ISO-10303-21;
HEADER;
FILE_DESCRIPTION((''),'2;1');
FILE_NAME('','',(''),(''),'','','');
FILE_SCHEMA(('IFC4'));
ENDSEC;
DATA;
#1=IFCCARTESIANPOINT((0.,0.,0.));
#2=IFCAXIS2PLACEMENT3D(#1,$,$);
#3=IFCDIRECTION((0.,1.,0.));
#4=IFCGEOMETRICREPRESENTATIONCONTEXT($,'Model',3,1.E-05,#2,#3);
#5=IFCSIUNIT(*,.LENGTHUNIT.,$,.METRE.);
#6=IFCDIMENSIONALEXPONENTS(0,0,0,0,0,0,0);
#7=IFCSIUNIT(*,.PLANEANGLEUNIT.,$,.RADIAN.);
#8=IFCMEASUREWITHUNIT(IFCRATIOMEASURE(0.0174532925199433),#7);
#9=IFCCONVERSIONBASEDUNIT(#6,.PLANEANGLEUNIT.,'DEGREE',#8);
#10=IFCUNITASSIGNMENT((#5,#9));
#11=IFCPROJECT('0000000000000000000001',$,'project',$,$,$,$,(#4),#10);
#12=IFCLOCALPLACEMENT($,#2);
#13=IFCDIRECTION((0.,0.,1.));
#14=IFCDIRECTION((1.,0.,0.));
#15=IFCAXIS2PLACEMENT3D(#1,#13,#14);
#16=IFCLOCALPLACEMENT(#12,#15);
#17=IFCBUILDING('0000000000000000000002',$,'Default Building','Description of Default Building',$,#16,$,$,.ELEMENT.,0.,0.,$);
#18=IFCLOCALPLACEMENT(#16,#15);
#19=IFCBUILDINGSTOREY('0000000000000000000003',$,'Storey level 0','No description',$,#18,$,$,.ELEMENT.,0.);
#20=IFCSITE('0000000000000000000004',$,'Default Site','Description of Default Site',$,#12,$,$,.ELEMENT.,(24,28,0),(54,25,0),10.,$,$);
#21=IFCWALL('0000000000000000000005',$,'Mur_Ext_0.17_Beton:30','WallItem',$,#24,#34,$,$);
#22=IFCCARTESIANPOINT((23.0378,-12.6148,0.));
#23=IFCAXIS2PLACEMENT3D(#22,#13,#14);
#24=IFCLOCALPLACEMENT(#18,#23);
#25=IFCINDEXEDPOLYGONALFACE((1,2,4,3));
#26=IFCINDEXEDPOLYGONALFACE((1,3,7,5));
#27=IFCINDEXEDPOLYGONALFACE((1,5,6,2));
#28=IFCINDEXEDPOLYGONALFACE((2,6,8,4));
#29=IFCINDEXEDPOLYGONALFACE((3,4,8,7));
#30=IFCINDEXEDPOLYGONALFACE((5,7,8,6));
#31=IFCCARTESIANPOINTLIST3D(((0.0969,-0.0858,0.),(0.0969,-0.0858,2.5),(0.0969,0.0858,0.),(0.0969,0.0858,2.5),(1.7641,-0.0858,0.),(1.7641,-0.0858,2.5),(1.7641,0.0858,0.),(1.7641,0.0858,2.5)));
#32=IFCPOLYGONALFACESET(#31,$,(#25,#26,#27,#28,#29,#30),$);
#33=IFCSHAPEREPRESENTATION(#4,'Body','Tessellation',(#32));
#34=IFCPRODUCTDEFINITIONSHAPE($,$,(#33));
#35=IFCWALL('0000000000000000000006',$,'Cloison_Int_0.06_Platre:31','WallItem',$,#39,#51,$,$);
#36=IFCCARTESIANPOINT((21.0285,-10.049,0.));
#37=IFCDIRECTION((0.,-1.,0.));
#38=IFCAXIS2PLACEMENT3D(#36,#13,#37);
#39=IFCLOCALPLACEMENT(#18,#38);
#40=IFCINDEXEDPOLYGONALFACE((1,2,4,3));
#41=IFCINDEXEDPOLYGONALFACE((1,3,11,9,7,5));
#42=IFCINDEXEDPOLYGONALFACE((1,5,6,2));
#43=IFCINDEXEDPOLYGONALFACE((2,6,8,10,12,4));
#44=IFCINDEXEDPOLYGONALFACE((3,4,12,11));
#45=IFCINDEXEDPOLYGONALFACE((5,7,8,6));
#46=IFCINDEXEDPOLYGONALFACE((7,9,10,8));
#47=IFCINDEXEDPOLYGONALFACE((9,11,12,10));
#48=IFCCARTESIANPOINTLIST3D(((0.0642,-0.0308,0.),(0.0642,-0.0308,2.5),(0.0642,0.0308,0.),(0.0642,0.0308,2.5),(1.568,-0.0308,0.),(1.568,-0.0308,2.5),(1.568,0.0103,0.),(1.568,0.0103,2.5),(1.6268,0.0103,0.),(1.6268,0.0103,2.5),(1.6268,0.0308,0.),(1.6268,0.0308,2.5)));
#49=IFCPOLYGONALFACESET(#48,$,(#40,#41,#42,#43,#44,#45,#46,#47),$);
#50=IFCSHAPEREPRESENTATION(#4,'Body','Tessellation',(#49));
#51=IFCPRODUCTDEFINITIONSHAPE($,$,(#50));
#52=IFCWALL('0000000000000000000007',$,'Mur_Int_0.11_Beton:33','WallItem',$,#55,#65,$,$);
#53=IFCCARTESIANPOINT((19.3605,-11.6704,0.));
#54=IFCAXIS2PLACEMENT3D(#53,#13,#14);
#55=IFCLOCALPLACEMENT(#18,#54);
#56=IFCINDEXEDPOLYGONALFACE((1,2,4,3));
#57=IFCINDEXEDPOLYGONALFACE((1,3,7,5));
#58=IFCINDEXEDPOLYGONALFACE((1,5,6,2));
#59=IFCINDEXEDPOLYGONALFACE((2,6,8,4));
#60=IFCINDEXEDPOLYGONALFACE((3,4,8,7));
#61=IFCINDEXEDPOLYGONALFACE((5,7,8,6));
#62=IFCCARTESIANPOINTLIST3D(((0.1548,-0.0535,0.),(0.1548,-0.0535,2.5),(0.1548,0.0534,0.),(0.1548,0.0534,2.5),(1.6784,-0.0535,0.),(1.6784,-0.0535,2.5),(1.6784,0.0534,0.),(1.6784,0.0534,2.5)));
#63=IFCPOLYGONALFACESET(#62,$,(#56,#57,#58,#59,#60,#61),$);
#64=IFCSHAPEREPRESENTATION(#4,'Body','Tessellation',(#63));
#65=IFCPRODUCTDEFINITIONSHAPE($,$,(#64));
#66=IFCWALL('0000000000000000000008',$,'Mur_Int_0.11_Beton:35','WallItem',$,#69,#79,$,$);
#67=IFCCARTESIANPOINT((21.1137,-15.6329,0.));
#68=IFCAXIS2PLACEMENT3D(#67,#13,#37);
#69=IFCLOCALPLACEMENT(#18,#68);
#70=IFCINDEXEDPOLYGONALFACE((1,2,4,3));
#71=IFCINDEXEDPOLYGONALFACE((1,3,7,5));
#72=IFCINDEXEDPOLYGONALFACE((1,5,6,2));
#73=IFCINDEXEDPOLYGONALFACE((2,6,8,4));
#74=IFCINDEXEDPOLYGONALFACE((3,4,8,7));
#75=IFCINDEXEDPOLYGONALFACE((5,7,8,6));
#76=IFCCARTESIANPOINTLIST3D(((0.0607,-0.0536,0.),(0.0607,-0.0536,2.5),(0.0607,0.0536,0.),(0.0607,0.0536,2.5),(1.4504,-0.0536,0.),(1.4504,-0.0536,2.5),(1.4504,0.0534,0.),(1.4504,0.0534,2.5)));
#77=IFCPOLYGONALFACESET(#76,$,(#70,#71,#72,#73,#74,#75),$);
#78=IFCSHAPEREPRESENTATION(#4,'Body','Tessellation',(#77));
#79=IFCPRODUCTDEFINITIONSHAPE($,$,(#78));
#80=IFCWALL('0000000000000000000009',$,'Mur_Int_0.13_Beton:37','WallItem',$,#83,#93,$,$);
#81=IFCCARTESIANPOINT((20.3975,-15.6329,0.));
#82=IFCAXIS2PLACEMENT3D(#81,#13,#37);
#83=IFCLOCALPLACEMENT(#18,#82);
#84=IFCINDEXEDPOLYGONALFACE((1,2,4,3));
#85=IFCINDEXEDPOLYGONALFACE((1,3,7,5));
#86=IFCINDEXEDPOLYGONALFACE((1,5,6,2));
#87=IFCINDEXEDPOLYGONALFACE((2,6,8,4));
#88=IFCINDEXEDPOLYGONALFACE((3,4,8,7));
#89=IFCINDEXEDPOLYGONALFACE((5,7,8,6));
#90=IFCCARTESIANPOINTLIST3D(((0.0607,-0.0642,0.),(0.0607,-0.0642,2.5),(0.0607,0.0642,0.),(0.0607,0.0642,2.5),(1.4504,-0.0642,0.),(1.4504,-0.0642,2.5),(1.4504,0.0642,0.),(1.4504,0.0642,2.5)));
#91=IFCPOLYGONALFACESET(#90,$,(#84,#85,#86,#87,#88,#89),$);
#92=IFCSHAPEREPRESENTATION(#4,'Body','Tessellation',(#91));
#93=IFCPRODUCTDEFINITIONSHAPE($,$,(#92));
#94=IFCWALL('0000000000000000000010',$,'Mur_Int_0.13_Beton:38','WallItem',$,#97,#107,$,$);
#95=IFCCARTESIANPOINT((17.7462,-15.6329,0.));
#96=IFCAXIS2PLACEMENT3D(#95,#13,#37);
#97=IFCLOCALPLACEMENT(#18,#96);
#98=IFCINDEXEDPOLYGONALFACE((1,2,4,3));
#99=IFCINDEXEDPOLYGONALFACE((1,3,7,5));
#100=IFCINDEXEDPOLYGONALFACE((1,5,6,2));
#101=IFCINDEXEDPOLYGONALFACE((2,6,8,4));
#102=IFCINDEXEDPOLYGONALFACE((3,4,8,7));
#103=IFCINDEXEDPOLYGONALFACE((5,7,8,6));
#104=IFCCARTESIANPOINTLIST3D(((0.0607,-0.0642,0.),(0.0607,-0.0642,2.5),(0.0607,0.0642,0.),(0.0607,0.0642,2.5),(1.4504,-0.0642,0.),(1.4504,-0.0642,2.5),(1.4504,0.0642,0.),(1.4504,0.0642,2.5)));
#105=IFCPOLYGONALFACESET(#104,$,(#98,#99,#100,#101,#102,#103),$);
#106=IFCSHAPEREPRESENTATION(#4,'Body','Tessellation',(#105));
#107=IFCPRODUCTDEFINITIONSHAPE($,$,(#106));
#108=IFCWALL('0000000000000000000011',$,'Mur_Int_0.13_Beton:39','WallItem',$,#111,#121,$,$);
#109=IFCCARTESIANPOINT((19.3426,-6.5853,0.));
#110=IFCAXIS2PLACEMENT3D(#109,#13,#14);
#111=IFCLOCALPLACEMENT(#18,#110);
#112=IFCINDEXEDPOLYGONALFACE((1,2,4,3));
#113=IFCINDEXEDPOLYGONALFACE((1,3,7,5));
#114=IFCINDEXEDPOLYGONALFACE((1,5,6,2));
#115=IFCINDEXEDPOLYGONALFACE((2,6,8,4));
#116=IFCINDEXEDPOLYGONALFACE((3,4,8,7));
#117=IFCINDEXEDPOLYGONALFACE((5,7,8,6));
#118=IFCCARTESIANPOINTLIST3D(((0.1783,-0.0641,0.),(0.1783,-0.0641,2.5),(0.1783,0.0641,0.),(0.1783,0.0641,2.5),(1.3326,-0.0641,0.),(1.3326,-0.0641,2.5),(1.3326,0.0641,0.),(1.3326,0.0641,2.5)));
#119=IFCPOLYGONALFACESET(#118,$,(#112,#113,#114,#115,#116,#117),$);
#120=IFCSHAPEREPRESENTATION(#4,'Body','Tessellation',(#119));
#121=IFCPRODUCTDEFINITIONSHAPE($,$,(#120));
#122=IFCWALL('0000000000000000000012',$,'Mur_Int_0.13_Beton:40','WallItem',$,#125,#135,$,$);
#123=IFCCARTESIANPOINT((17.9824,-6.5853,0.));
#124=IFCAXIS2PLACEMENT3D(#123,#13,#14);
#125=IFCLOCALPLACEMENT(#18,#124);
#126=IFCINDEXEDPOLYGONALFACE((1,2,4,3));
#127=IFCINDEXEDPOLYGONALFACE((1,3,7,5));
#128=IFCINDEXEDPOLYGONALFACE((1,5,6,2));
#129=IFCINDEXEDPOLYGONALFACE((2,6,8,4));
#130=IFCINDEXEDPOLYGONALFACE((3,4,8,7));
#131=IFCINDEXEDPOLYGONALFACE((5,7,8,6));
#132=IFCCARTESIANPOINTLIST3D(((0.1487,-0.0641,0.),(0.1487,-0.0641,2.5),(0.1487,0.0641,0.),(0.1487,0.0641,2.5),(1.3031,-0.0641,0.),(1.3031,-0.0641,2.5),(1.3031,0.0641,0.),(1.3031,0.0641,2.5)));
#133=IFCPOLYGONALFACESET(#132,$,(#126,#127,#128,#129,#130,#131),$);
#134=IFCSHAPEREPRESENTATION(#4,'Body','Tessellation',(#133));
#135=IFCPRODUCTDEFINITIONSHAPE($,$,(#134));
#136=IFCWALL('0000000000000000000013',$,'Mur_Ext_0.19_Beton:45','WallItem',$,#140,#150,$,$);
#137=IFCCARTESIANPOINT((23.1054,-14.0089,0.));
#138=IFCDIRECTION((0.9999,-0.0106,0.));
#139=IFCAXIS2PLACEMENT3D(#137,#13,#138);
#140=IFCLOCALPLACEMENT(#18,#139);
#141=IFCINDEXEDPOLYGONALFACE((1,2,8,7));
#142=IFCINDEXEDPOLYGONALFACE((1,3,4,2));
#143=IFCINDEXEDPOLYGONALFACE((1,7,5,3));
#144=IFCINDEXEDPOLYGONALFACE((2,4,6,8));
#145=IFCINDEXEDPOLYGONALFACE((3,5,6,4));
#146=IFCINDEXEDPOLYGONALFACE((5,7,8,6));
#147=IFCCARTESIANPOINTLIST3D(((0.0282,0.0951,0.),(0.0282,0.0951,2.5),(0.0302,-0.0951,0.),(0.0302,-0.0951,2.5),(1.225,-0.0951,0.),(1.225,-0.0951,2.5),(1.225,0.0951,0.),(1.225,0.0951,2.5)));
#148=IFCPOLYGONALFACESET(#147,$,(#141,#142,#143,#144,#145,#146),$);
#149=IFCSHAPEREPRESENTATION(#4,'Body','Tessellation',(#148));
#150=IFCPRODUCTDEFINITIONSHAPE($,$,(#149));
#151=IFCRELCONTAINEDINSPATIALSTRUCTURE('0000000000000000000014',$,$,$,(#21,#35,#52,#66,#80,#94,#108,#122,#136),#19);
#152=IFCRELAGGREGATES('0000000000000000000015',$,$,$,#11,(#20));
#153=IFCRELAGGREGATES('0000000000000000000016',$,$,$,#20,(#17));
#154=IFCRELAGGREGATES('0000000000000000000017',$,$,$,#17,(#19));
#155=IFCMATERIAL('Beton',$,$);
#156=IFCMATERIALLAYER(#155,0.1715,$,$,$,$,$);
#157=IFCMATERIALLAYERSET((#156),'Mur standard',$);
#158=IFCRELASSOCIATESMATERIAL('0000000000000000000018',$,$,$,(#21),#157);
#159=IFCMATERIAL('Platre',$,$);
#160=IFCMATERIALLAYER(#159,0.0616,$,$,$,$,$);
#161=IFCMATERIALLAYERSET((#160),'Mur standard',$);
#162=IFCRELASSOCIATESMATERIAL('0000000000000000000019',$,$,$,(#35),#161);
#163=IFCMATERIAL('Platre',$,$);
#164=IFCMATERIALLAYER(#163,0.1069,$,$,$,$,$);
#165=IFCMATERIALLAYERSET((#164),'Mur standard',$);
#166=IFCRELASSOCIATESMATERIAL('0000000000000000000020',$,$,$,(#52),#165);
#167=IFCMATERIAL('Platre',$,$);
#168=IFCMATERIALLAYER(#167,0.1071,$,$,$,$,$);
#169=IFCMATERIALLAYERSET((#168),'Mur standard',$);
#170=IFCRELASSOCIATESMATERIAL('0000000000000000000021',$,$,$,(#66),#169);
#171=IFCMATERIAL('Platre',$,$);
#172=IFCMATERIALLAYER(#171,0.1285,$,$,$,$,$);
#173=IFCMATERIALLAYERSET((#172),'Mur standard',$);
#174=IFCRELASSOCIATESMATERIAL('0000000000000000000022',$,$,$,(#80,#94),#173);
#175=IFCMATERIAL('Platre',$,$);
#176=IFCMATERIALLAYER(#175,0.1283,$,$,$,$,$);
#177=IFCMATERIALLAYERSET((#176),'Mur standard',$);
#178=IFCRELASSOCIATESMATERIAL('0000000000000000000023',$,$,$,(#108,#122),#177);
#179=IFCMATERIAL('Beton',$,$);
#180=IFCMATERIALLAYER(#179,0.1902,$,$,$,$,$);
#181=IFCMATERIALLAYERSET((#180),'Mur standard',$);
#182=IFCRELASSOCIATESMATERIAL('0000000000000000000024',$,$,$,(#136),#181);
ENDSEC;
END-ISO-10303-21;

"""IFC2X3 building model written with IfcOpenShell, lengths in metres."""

from ifc_helpers import new_model, entity, si_unit, converted_unit, direction, frame, origin, origin_with_axes, place, context, project, spatial, polyline, outline, extrude, material, layer, layer_set, layer_usage, element, save


model = new_model("IFC2X3")

# Units and contexts
model_context = context("Model", 3, precision=1e-05, world=origin(), true_north=direction((0.0, 1.0, 0.0)))
ifc_project = project(units=[si_unit("LENGTHUNIT", "METRE"), converted_unit("PLANEANGLEUNIT", "DEGREE", entity("IfcRatioMeasure", 0.0174532925199433), si_unit("PLANEANGLEUNIT", "RADIAN"), dimensions=[0, 0, 0, 0, 0, 0, 0])], contexts=[model_context])

# Site, building, storey
site_placement = place(None, origin())
site = spatial("IfcSite", under=ifc_project, at=site_placement, Name="Default Site", Description="Description of Default Site", CompositionType="ELEMENT", RefLatitude=(24, 28, 0), RefLongitude=(54, 25, 0), RefElevation=10.0)
building_placement = place(site_placement, origin_with_axes())
building = spatial("IfcBuilding", under=site, at=building_placement, Name="Default Building", Description="Description of Default Building", CompositionType="ELEMENT", ElevationOfRefHeight=0.0, ElevationOfTerrain=0.0)
storey_placement = place(building_placement, origin_with_axes())
storey = spatial("IfcBuildingStorey", under=building, at=storey_placement, Name="Storey level 0", Description="No description", CompositionType="ELEMENT", Elevation=0.0)

# Shared definitions
ifc_material_1 = material(Name="Platre")
ifc_layer_1 = layer(ifc_material_1, 0.1283)
ifc_layer_set_1 = layer_set([ifc_layer_1], Name="Mur standard")
ifc_layer_usage_1 = layer_usage(ifc_layer_set_1, "AXIS2", "NEGATIVE", 0.1283)

# Shared definitions
ifc_material_2 = material(Name="Beton")
ifc_layer_2 = layer(ifc_material_2, 0.1715)
ifc_layer_set_2 = layer_set([ifc_layer_2], Name="Mur standard")
ifc_layer_usage_2 = layer_usage(ifc_layer_set_2, "AXIS2", "NEGATIVE", 0.1715)

# Walls
wall_1_placement = place(storey_placement, frame((23.0378, -12.6148, 0.0), z_axis=(0.0, 0.0, 1.0), x_axis=(1.0, 0.0, 0.0)))
element("IfcWall", 1, at=wall_1_placement, inside=storey, material=ifc_layer_usage_2, Name="Mur_Ext_0.17_Beton:30", Description="WallItem", context=model_context, shape_type="SweptSolid", body=[
    extrude(outline(polyline([(0.0969, 0.0858), (0.0969, -0.0858), (1.7641, -0.0858), (1.7641, 0.0858), (0.0969, 0.0858)])), origin(), (0.0, 0.0, 1.0), 2.5),
])
ifc_material_3 = material(Name="Platre")
ifc_layer_3 = layer(ifc_material_3, 0.0616)
ifc_layer_set_3 = layer_set([ifc_layer_3], Name="Mur standard")
ifc_layer_usage_3 = layer_usage(ifc_layer_set_3, "AXIS2", "NEGATIVE", 0.0616)
wall_2_placement = place(storey_placement, frame((21.0285, -10.049, 0.0), z_axis=(0.0, 0.0, 1.0), x_axis=(0.0, -1.0, 0.0)))
element("IfcWall", 2, at=wall_2_placement, inside=storey, material=ifc_layer_usage_3, Name="Cloison_Int_0.06_Platre:31", Description="WallItem", context=model_context, shape_type="SweptSolid", body=[
    extrude(outline(polyline([(1.6268, 0.0308), (1.6268, 0.0103), (1.568, 0.0103), (1.568, -0.0308), (0.0642, -0.0308), (0.0642, 0.0308), (1.6268, 0.0308)])), origin(), (0.0, 0.0, 1.0), 2.5),
])
ifc_material_4 = material(Name="Platre")
ifc_layer_4 = layer(ifc_material_4, 0.1069)
ifc_layer_set_4 = layer_set([ifc_layer_4], Name="Mur standard")
ifc_layer_usage_4 = layer_usage(ifc_layer_set_4, "AXIS2", "NEGATIVE", 0.1069)
wall_3_placement = place(storey_placement, frame((19.3605, -11.6704, 0.0), z_axis=(0.0, 0.0, 1.0), x_axis=(1.0, 0.0, 0.0)))
element("IfcWall", 3, at=wall_3_placement, inside=storey, material=ifc_layer_usage_4, Name="Mur_Int_0.11_Beton:33", Description="WallItem", context=model_context, shape_type="SweptSolid", body=[
    extrude(outline(polyline([(0.1548, 0.0534), (0.1548, -0.0535), (1.6784, -0.0535), (1.6784, 0.0534), (0.1548, 0.0534)])), origin(), (0.0, 0.0, 1.0), 2.5),
])
ifc_material_5 = material(Name="Platre")
ifc_layer_5 = layer(ifc_material_5, 0.1071)
ifc_layer_set_5 = layer_set([ifc_layer_5], Name="Mur standard")
ifc_layer_usage_5 = layer_usage(ifc_layer_set_5, "AXIS2", "NEGATIVE", 0.1071)
wall_4_placement = place(storey_placement, frame((21.1137, -15.6329, 0.0), z_axis=(0.0, 0.0, 1.0), x_axis=(0.0, -1.0, 0.0)))
element("IfcWall", 4, at=wall_4_placement, inside=storey, material=ifc_layer_usage_5, Name="Mur_Int_0.11_Beton:35", Description="WallItem", context=model_context, shape_type="SweptSolid", body=[
    extrude(outline(polyline([(1.4504, 0.0534), (1.4504, -0.0536), (0.0607, -0.0536), (0.0607, 0.0536), (1.4504, 0.0534)])), origin(), (0.0, 0.0, 1.0), 2.5),
])
ifc_material_6 = material(Name="Platre")
ifc_layer_6 = layer(ifc_material_6, 0.1285)
ifc_layer_set_6 = layer_set([ifc_layer_6], Name="Mur standard")
ifc_layer_usage_6 = layer_usage(ifc_layer_set_6, "AXIS2", "NEGATIVE", 0.1285)
for number, where, z_axis, x_axis, name in (
    (5, (20.3975, -15.6329, 0.0), (0.0, 0.0, 1.0), (0.0, -1.0, 0.0), "Mur_Int_0.13_Beton:37"),
    (6, (17.7462, -15.6329, 0.0), (0.0, 0.0, 1.0), (0.0, -1.0, 0.0), "Mur_Int_0.13_Beton:38"),
):
    element("IfcWall", number, at=place(storey_placement, frame(where, z_axis=z_axis, x_axis=x_axis)), inside=storey, material=ifc_layer_usage_6, Name=name, Description="WallItem", context=model_context, shape_type="SweptSolid", body=[
        extrude(outline(polyline([(0.0607, -0.0642), (1.4504, -0.0642), (1.4504, 0.0642), (0.0607, 0.0642), (0.0607, -0.0642)])), origin(), (0.0, 0.0, 1.0), 2.5),
    ])
wall_5_placement = place(storey_placement, frame((19.3426, -6.5853, 0.0), z_axis=(0.0, 0.0, 1.0), x_axis=(1.0, 0.0, 0.0)))
element("IfcWall", 7, at=wall_5_placement, inside=storey, material=ifc_layer_usage_1, Name="Mur_Int_0.13_Beton:39", Description="WallItem", context=model_context, shape_type="SweptSolid", body=[
    extrude(outline(polyline([(0.1783, 0.0641), (0.1783, -0.0641), (1.3326, -0.0641), (1.3326, 0.0641), (0.1783, 0.0641)])), origin(), (0.0, 0.0, 1.0), 2.5),
])
wall_6_placement = place(storey_placement, frame((17.9824, -6.5853, 0.0), z_axis=(0.0, 0.0, 1.0), x_axis=(1.0, 0.0, 0.0)))
element("IfcWall", 8, at=wall_6_placement, inside=storey, material=ifc_layer_usage_1, Name="Mur_Int_0.13_Beton:40", Description="WallItem", context=model_context, shape_type="SweptSolid", body=[
    extrude(outline(polyline([(0.1487, 0.0641), (0.1487, -0.0641), (1.3031, -0.0641), (1.3031, 0.0641), (0.1487, 0.0641)])), origin(), (0.0, 0.0, 1.0), 2.5),
])
ifc_material_7 = material(Name="Beton")
ifc_layer_7 = layer(ifc_material_7, 0.1902)
ifc_layer_set_7 = layer_set([ifc_layer_7], Name="Mur standard")
ifc_layer_usage_7 = layer_usage(ifc_layer_set_7, "AXIS2", "NEGATIVE", 0.1902)
wall_7_placement = place(storey_placement, frame((23.1054, -14.0089, 0.0), z_axis=(0.0, 0.0, 1.0), x_axis=(0.9999, -0.0106, 0.0)))
element("IfcWall", 9, at=wall_7_placement, inside=storey, material=ifc_layer_usage_7, Name="Mur_Ext_0.19_Beton:45", Description="WallItem", context=model_context, shape_type="SweptSolid", body=[
    extrude(outline(polyline([(0.0282, 0.0951), (0.0302, -0.0951), (1.225, -0.0951), (1.225, 0.0951), (0.0282, 0.0951)])), origin(), (0.0, 0.0, 1.0), 2.5),
])

save(model, "model.ifc")
